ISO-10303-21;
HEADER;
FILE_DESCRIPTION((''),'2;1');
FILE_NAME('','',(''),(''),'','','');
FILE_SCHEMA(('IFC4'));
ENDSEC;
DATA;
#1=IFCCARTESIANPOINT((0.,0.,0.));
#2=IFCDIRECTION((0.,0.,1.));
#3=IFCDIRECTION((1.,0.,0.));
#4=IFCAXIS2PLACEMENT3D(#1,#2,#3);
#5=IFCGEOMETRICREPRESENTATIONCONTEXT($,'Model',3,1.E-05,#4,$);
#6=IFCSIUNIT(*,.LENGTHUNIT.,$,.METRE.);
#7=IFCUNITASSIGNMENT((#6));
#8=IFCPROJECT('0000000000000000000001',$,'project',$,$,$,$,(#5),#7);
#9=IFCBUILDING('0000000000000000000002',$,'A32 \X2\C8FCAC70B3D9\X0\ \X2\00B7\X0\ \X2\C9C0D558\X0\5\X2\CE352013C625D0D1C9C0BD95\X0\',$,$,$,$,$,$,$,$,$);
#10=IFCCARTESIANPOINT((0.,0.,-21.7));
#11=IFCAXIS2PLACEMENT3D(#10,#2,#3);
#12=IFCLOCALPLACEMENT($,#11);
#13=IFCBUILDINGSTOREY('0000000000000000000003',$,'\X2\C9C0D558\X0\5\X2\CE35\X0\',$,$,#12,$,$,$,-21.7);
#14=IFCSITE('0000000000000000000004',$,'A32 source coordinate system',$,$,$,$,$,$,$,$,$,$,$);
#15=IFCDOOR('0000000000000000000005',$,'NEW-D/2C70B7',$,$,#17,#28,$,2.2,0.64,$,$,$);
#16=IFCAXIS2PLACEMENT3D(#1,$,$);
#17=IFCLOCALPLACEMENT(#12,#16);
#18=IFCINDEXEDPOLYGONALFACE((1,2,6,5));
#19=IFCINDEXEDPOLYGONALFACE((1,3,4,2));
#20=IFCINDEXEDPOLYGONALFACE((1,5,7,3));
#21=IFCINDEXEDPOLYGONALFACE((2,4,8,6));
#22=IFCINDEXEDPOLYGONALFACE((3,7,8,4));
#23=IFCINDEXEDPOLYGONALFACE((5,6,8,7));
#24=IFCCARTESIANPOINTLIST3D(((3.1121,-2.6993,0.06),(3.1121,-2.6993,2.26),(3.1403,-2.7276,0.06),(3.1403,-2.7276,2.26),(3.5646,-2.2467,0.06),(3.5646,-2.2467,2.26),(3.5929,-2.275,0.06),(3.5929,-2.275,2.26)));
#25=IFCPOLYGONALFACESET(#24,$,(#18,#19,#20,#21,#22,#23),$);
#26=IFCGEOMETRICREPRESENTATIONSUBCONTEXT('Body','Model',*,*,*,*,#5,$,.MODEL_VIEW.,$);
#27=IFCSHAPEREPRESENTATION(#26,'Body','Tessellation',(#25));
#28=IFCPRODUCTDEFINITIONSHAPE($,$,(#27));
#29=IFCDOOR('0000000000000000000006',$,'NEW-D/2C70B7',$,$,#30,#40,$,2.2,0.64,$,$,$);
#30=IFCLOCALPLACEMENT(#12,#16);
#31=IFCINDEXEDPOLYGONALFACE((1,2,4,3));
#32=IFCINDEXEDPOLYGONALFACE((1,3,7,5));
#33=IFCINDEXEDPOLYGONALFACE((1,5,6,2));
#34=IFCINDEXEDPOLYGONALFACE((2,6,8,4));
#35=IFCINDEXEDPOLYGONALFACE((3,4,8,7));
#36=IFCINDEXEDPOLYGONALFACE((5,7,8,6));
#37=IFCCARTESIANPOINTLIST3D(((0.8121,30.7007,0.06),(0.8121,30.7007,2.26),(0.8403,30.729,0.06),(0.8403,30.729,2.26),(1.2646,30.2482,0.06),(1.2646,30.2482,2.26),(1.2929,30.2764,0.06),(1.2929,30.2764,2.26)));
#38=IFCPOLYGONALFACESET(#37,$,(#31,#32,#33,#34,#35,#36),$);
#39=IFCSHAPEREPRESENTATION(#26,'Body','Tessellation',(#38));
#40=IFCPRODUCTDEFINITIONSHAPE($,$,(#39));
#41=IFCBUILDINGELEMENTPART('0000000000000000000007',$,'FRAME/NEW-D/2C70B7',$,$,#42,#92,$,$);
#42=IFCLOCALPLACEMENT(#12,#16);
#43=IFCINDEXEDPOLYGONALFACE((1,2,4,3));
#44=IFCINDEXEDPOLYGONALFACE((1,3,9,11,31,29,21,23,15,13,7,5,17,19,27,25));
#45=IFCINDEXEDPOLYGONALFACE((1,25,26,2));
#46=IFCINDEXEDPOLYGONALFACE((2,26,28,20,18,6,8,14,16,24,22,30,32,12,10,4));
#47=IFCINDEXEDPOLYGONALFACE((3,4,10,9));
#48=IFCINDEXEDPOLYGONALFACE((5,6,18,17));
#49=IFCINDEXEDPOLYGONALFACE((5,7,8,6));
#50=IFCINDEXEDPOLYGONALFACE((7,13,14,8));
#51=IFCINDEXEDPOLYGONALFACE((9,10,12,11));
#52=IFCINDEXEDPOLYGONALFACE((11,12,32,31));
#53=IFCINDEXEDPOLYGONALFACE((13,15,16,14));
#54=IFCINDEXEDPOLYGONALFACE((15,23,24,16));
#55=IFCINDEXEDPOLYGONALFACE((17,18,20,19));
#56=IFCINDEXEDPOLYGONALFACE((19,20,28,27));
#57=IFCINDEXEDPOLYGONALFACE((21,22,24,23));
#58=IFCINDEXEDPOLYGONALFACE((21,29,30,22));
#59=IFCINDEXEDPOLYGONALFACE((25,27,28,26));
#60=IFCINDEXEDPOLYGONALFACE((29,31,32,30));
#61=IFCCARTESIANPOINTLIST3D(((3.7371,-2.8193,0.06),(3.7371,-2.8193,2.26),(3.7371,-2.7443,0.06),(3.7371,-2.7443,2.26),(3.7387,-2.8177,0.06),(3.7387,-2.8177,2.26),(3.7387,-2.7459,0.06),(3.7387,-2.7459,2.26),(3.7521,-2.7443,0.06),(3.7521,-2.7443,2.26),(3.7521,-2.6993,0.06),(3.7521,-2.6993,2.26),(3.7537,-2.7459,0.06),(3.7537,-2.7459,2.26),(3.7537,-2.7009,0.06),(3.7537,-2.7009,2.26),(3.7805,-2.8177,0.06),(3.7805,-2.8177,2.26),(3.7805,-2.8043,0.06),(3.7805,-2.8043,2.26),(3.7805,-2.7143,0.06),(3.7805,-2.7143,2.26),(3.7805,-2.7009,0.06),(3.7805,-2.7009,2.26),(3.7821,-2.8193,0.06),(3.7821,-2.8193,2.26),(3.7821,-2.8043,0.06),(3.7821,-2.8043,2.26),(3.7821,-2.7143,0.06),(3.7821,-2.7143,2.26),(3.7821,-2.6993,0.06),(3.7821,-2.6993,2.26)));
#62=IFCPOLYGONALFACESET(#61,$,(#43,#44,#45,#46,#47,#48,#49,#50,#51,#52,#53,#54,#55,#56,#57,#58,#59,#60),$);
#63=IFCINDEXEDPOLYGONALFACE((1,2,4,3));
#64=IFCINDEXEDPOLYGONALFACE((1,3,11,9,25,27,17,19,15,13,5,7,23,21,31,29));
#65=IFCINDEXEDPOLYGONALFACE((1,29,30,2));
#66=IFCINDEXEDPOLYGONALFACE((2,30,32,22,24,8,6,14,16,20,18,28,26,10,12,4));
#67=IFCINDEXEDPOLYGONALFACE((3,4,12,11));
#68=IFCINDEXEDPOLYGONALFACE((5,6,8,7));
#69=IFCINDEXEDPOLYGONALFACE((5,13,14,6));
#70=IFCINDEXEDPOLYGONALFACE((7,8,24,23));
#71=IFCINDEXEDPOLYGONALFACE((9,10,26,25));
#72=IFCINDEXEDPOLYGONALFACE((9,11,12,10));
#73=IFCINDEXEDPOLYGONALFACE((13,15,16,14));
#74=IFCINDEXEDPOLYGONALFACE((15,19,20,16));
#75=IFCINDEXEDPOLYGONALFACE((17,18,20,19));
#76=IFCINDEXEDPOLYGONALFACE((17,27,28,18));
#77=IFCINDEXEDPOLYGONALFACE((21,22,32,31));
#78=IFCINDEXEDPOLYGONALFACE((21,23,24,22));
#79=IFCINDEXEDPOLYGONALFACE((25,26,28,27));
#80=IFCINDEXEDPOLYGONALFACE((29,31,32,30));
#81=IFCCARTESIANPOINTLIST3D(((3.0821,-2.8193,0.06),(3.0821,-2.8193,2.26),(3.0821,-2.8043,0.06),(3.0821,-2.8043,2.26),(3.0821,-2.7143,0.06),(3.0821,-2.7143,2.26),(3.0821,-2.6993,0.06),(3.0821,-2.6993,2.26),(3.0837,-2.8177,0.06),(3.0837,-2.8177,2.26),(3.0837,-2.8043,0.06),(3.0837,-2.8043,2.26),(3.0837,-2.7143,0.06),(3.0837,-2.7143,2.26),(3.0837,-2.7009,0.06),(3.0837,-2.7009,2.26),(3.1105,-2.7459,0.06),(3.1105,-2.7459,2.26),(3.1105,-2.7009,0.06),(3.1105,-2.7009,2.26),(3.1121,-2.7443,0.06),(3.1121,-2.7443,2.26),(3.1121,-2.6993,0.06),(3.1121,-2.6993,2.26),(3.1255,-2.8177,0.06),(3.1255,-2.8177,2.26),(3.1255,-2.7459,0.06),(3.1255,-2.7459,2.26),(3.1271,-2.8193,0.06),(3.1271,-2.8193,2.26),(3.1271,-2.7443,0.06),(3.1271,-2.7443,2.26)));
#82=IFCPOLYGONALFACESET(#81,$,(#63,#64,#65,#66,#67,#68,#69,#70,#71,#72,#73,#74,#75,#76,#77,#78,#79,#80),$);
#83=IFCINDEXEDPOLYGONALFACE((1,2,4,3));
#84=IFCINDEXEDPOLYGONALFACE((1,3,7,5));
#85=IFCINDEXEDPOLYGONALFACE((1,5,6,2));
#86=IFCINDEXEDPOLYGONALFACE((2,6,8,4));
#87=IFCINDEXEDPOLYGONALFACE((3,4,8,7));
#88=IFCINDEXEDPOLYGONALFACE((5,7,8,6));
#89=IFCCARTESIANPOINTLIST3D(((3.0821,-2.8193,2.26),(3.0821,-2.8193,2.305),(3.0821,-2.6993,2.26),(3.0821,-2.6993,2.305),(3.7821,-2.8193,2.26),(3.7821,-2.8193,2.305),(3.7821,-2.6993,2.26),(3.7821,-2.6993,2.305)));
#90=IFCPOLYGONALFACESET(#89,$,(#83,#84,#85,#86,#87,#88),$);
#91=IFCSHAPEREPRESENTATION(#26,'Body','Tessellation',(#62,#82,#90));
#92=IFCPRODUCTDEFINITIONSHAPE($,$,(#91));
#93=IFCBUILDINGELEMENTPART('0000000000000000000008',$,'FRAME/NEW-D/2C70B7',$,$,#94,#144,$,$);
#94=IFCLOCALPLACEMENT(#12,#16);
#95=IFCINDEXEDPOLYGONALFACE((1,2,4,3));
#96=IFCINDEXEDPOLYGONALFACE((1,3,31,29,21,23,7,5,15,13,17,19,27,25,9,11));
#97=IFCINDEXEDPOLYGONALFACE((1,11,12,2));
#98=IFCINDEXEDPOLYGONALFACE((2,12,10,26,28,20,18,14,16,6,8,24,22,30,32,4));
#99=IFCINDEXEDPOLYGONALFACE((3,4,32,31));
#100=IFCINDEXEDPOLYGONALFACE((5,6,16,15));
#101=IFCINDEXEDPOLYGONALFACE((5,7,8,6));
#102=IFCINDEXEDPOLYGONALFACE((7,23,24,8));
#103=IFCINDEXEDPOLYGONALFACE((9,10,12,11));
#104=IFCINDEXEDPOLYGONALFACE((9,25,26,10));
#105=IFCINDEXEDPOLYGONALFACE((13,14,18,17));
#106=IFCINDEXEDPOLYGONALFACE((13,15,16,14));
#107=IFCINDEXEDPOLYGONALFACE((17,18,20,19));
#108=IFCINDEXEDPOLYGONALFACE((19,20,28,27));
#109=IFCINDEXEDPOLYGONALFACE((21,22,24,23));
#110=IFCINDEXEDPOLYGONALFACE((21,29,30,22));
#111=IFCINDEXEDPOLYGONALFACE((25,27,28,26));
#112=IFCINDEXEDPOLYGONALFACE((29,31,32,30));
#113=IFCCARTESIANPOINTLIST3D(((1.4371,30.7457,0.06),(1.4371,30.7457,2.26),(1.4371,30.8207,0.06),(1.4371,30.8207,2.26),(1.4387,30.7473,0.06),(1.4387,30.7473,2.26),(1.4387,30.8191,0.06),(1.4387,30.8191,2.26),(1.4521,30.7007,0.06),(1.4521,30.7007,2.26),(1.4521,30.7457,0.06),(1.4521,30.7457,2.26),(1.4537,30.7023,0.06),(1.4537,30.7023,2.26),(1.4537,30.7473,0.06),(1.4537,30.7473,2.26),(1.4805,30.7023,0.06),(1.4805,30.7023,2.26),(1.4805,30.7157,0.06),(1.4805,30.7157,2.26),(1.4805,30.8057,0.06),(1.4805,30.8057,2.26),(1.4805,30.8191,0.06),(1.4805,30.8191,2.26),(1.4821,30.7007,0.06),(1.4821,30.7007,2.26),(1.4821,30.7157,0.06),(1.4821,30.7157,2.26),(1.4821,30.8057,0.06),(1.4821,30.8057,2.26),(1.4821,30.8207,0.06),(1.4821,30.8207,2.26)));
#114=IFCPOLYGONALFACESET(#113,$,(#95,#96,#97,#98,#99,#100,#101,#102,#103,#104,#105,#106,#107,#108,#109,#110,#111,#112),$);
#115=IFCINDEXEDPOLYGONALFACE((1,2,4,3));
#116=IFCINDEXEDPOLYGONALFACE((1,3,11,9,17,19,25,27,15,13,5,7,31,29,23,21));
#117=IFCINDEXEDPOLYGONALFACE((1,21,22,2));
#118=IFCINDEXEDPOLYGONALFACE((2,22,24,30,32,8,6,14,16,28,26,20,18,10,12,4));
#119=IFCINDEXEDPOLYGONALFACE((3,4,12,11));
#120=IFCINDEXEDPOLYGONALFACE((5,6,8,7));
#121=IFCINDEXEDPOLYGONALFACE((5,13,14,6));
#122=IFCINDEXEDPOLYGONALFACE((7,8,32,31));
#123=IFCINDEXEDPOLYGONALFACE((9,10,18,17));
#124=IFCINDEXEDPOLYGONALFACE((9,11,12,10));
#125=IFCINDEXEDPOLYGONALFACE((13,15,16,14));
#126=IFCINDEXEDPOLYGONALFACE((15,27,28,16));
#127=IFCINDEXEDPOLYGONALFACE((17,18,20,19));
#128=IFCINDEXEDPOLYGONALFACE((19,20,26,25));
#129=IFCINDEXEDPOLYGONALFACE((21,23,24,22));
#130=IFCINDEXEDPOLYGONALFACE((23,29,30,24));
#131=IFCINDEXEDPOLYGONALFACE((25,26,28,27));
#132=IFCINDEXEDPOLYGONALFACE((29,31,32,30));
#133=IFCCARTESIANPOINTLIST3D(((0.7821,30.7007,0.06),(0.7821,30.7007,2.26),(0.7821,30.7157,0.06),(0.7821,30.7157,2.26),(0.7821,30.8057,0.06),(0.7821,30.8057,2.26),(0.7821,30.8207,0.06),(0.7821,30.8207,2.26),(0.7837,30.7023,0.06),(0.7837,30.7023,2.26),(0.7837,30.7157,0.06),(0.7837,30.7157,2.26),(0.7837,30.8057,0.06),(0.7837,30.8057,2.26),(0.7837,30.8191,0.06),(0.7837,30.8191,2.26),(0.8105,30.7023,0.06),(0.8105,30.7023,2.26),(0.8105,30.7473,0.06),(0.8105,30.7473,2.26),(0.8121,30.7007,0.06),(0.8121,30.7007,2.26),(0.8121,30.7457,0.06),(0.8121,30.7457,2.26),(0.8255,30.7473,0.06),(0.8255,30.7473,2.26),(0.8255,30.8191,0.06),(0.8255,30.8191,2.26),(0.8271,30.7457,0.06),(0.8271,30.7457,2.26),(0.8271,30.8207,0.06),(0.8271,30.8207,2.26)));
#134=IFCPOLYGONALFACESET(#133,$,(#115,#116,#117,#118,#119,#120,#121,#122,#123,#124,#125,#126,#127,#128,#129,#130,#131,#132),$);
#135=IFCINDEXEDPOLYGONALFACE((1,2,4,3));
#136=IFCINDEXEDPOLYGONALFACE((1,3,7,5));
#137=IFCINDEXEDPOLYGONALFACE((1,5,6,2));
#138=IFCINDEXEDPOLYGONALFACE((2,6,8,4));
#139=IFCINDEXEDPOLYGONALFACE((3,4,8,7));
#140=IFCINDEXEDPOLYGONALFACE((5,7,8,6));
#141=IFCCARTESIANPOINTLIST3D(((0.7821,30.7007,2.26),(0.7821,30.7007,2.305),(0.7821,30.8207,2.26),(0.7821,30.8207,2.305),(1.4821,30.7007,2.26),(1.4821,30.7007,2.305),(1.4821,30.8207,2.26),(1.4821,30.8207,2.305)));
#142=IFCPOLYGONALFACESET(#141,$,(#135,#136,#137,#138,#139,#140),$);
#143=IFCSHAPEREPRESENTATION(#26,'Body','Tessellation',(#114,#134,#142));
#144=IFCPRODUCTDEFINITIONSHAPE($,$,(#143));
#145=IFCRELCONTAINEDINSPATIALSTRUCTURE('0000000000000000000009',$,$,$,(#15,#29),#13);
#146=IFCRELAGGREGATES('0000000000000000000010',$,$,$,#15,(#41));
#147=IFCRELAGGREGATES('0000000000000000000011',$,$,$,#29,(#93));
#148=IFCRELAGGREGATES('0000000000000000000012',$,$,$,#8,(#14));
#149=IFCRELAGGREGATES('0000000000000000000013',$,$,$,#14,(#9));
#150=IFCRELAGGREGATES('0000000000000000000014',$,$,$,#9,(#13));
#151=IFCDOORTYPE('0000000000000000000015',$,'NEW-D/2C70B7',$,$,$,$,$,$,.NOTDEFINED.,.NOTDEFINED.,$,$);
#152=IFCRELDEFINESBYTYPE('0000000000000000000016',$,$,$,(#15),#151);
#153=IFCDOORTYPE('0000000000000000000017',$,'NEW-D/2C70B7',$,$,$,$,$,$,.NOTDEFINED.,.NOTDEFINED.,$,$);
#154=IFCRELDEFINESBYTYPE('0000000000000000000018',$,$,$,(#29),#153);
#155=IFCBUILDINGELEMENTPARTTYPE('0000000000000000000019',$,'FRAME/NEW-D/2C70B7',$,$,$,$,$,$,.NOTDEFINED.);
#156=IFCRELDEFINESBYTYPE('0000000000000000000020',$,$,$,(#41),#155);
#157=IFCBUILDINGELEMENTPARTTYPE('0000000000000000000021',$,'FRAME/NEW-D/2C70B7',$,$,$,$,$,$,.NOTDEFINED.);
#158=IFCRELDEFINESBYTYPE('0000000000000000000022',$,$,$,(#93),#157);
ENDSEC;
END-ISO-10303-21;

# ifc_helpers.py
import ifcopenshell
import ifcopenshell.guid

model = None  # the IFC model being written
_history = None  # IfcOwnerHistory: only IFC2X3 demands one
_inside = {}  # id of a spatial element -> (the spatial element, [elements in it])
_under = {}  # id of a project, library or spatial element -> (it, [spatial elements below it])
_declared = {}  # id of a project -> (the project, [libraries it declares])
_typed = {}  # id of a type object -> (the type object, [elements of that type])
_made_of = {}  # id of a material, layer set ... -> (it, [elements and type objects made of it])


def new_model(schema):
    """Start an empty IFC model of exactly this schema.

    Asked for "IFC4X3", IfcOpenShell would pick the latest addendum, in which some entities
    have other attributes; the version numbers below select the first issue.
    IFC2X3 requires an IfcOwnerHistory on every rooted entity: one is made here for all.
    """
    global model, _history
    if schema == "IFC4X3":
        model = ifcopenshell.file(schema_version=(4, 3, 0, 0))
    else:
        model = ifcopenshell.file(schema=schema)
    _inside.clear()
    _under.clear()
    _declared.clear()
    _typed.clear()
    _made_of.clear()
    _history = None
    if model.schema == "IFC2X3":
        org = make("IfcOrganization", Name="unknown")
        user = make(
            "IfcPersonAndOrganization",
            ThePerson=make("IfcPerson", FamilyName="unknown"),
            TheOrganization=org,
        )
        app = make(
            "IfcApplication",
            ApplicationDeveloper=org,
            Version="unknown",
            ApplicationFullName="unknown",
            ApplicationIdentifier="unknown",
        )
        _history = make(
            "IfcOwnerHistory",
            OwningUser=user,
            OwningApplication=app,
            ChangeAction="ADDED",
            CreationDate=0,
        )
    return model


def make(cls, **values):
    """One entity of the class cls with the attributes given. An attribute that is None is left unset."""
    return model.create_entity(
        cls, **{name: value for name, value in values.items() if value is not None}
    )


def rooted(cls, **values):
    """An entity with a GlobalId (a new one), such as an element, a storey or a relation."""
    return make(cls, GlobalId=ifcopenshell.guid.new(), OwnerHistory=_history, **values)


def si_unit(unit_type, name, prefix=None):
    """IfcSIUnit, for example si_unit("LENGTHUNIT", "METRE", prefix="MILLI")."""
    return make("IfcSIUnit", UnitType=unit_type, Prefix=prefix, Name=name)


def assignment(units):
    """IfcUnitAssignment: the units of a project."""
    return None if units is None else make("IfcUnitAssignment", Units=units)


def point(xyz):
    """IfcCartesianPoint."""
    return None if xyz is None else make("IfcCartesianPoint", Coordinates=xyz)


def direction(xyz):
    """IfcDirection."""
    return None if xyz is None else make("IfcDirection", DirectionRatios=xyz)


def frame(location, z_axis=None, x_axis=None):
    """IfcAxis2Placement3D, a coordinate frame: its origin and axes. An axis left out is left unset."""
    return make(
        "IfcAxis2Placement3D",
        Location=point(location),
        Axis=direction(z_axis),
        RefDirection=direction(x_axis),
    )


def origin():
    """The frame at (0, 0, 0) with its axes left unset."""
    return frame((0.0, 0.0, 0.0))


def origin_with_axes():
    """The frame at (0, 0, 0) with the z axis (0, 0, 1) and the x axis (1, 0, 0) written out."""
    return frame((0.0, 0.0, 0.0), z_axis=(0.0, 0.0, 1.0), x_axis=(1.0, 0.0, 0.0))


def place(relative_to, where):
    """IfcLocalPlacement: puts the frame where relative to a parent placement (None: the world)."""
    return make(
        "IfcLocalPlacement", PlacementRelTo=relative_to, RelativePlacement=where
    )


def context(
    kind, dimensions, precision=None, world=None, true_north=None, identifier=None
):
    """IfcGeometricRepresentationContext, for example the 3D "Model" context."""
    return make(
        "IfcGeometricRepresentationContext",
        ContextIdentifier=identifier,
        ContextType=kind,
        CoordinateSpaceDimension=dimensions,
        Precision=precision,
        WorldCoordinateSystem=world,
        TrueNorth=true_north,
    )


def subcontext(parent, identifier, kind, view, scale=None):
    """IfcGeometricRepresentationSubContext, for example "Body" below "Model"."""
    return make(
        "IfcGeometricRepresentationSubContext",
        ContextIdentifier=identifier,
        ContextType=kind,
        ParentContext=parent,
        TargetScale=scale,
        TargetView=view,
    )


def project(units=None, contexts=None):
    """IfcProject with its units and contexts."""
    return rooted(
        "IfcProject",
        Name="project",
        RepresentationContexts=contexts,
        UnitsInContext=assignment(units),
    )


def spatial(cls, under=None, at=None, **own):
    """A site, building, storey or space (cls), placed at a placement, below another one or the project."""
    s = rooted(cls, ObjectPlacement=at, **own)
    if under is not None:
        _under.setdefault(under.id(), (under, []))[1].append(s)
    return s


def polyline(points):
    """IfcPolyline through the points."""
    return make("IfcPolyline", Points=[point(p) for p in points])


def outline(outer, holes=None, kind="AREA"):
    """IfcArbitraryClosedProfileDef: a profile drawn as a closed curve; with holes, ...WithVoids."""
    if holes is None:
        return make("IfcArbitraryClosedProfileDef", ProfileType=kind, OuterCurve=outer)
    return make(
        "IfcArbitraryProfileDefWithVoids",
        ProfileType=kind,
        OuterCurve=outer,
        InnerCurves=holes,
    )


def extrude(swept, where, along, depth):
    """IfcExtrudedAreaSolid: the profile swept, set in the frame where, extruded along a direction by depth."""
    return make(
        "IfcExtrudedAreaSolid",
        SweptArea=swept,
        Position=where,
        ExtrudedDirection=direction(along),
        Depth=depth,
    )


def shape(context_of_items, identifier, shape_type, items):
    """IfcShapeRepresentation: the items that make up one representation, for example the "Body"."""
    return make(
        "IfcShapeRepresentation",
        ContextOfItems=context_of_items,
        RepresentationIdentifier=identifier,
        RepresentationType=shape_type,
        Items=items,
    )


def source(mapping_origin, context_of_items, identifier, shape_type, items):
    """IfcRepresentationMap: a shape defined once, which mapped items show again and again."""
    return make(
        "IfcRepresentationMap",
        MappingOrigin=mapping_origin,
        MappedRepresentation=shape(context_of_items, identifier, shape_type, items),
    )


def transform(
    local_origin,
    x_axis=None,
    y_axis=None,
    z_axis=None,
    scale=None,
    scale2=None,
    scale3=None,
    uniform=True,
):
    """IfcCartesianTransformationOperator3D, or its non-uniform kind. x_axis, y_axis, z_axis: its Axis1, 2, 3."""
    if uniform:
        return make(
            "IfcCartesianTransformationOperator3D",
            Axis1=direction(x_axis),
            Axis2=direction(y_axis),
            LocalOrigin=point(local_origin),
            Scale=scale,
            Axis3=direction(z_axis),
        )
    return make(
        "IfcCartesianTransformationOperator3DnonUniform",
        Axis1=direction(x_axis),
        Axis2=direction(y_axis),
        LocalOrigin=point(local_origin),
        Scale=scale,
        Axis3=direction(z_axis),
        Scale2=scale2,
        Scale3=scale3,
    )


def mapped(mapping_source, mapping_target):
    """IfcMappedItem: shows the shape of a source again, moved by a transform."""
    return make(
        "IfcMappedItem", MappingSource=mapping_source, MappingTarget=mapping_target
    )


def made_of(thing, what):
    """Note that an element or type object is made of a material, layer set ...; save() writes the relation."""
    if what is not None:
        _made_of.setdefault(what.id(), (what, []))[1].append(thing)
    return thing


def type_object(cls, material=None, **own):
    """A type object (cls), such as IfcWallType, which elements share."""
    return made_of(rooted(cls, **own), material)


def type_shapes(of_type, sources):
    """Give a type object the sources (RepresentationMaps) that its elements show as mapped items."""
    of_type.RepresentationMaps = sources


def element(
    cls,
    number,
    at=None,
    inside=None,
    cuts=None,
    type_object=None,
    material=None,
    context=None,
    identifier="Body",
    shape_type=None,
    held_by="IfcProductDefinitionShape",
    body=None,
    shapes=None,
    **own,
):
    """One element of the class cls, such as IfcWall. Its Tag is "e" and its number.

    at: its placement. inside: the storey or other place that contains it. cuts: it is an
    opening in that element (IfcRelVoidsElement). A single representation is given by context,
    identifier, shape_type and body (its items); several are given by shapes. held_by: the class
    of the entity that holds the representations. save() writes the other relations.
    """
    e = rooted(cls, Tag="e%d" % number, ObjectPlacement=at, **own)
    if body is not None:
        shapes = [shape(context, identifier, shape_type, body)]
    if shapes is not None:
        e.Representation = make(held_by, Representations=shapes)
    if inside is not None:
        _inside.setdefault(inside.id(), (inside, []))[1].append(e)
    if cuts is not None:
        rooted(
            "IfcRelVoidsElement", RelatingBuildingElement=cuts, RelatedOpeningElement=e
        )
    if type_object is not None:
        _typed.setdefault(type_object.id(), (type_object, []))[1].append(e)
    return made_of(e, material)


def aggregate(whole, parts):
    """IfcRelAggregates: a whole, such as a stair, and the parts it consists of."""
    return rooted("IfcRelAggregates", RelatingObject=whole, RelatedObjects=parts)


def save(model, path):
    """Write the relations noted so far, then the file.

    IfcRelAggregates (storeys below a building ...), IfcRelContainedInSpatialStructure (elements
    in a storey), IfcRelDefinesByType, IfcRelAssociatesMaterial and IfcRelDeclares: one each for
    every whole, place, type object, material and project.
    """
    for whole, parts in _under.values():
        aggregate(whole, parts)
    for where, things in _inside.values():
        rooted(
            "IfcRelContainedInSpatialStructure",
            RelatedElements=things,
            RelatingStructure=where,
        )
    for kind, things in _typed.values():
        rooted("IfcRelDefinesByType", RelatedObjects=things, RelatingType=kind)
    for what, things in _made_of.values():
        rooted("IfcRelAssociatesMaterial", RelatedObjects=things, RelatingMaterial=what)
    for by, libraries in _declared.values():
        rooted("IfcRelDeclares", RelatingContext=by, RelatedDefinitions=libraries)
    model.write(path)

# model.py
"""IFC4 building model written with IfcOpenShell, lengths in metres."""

from ifc_helpers import new_model, si_unit, frame, origin, origin_with_axes, place, context, subcontext, project, spatial, polyline, outline, extrude, source, transform, mapped, type_object, type_shapes, element, aggregate, save


model = new_model("IFC4")

# Units and contexts
model_context = context("Model", 3, precision=1e-05, world=origin_with_axes())
body_context = subcontext(model_context, "Body", "Model", "MODEL_VIEW")
ifc_project = project(units=[si_unit("LENGTHUNIT", "METRE")], contexts=[model_context])

# Site, building, storey
site = spatial("IfcSite", under=ifc_project, Name="A32 source coordinate system")
building = spatial("IfcBuilding", under=site, Name="A32 주거동 · 지하5층–옥탑지붕")
storey_placement = place(None, frame((0.0, 0.0, -21.7), z_axis=(0.0, 0.0, 1.0), x_axis=(1.0, 0.0, 0.0)))
storey = spatial("IfcBuildingStorey", under=building, at=storey_placement, Name="지하5층", Elevation=-21.7)

# Doors
door_type_1 = type_object("IfcDoorType", Name="NEW-D/2C70B7", OperationType="NOTDEFINED", PredefinedType="NOTDEFINED")
shared_shape_1 = source(origin(), body_context, "Body", "SweptSolid", [
    extrude(outline(polyline([(3.5929, -2.275), (3.1403, -2.7276), (3.1121, -2.6993), (3.5646, -2.2467), (3.5929, -2.275)])), frame((0.0, 0.0, 0.06)), (0.0, 0.0, 1.0), 2.2),
])
type_shapes(door_type_1, [shared_shape_1])
door_1_placement = place(storey_placement, origin_with_axes())
door_1 = element("IfcDoor", 1, at=door_1_placement, inside=storey, type_object=door_type_1, Name="NEW-D/2C70B7", OverallHeight=2.2, OverallWidth=0.64, context=body_context, shape_type="MappedRepresentation", body=[
    mapped(shared_shape_1, transform((0.0, 0.0, 0.0), scale=1.0)),
])
door_type_2 = type_object("IfcDoorType", Name="NEW-D/2C70B7", OperationType="NOTDEFINED", PredefinedType="NOTDEFINED")
shared_shape_2 = source(origin(), body_context, "Body", "SweptSolid", [
    extrude(outline(polyline([(0.8121, 30.7007), (0.8403, 30.729), (1.2929, 30.2764), (1.2646, 30.2482), (0.8121, 30.7007)])), frame((0.0, 0.0, 0.06)), (0.0, 0.0, 1.0), 2.2),
])
type_shapes(door_type_2, [shared_shape_2])
door_2_placement = place(storey_placement, origin_with_axes())
door_2 = element("IfcDoor", 2, at=door_2_placement, inside=storey, type_object=door_type_2, Name="NEW-D/2C70B7", OverallHeight=2.2, OverallWidth=0.64, context=body_context, shape_type="MappedRepresentation", body=[
    mapped(shared_shape_2, transform((0.0, 0.0, 0.0), scale=1.0)),
])

# Building element parts
building_element_part_type_1 = type_object("IfcBuildingElementPartType", Name="FRAME/NEW-D/2C70B7", PredefinedType="NOTDEFINED")
shared_shape_3 = source(origin(), body_context, "Body", "SweptSolid", [
    extrude(outline(polyline([(3.7537, -2.7009), (3.7537, -2.7459), (3.7387, -2.7459), (3.7387, -2.8177), (3.7805, -2.8177), (3.7805, -2.8043), (3.7821, -2.8043), (3.7821, -2.8193), (3.7371, -2.8193), (3.7371, -2.7443), (3.7521, -2.7443), (3.7521, -2.6993), (3.7821, -2.6993), (3.7821, -2.7143), (3.7805, -2.7143), (3.7805, -2.7009), (3.7537, -2.7009)])), frame((0.0, 0.0, 0.06)), (0.0, 0.0, 1.0), 2.2),
    extrude(outline(polyline([(3.0821, -2.6993), (3.1121, -2.6993), (3.1121, -2.7443), (3.1271, -2.7443), (3.1271, -2.8193), (3.0821, -2.8193), (3.0821, -2.8043), (3.0837, -2.8043), (3.0837, -2.8177), (3.1255, -2.8177), (3.1255, -2.7459), (3.1105, -2.7459), (3.1105, -2.7009), (3.0837, -2.7009), (3.0837, -2.7143), (3.0821, -2.7143), (3.0821, -2.6993)])), frame((0.0, 0.0, 0.06)), (0.0, 0.0, 1.0), 2.2),
    extrude(outline(polyline([(3.7821, -2.8193), (3.7821, -2.6993), (3.0821, -2.6993), (3.0821, -2.8193), (3.7821, -2.8193)])), frame((0.0, 0.0, 2.26)), (0.0, 0.0, 1.0), 0.045),
])
type_shapes(building_element_part_type_1, [shared_shape_3])
building_element_part_1_placement = place(door_1_placement, origin_with_axes())
building_element_part_1 = element("IfcBuildingElementPart", 3, at=building_element_part_1_placement, type_object=building_element_part_type_1, Name="FRAME/NEW-D/2C70B7", context=body_context, shape_type="MappedRepresentation", body=[
    mapped(shared_shape_3, transform((0.0, 0.0, 0.0), scale=1.0)),
])
aggregate(door_1, [building_element_part_1])
building_element_part_type_2 = type_object("IfcBuildingElementPartType", Name="FRAME/NEW-D/2C70B7", PredefinedType="NOTDEFINED")
shared_shape_4 = source(origin(), body_context, "Body", "SweptSolid", [
    extrude(outline(polyline([(1.4821, 30.7007), (1.4521, 30.7007), (1.4521, 30.7457), (1.4371, 30.7457), (1.4371, 30.8207), (1.4821, 30.8207), (1.4821, 30.8057), (1.4805, 30.8057), (1.4805, 30.8191), (1.4387, 30.8191), (1.4387, 30.7473), (1.4537, 30.7473), (1.4537, 30.7023), (1.4805, 30.7023), (1.4805, 30.7157), (1.4821, 30.7157), (1.4821, 30.7007)])), frame((0.0, 0.0, 0.06)), (0.0, 0.0, 1.0), 2.2),
    extrude(outline(polyline([(0.8105, 30.7023), (0.8105, 30.7473), (0.8255, 30.7473), (0.8255, 30.8191), (0.7837, 30.8191), (0.7837, 30.8057), (0.7821, 30.8057), (0.7821, 30.8207), (0.8271, 30.8207), (0.8271, 30.7457), (0.8121, 30.7457), (0.8121, 30.7007), (0.7821, 30.7007), (0.7821, 30.7157), (0.7837, 30.7157), (0.7837, 30.7023), (0.8105, 30.7023)])), frame((0.0, 0.0, 0.06)), (0.0, 0.0, 1.0), 2.2),
    extrude(outline(polyline([(1.4821, 30.7007), (1.4821, 30.8207), (0.7821, 30.8207), (0.7821, 30.7007), (1.4821, 30.7007)])), frame((0.0, 0.0, 2.26)), (0.0, 0.0, 1.0), 0.045),
])
type_shapes(building_element_part_type_2, [shared_shape_4])
building_element_part_2_placement = place(door_2_placement, origin_with_axes())
building_element_part_2 = element("IfcBuildingElementPart", 4, at=building_element_part_2_placement, type_object=building_element_part_type_2, Name="FRAME/NEW-D/2C70B7", context=body_context, shape_type="MappedRepresentation", body=[
    mapped(shared_shape_4, transform((0.0, 0.0, 0.0), scale=1.0)),
])
aggregate(door_2, [building_element_part_2])

save(model, "model.ifc")
